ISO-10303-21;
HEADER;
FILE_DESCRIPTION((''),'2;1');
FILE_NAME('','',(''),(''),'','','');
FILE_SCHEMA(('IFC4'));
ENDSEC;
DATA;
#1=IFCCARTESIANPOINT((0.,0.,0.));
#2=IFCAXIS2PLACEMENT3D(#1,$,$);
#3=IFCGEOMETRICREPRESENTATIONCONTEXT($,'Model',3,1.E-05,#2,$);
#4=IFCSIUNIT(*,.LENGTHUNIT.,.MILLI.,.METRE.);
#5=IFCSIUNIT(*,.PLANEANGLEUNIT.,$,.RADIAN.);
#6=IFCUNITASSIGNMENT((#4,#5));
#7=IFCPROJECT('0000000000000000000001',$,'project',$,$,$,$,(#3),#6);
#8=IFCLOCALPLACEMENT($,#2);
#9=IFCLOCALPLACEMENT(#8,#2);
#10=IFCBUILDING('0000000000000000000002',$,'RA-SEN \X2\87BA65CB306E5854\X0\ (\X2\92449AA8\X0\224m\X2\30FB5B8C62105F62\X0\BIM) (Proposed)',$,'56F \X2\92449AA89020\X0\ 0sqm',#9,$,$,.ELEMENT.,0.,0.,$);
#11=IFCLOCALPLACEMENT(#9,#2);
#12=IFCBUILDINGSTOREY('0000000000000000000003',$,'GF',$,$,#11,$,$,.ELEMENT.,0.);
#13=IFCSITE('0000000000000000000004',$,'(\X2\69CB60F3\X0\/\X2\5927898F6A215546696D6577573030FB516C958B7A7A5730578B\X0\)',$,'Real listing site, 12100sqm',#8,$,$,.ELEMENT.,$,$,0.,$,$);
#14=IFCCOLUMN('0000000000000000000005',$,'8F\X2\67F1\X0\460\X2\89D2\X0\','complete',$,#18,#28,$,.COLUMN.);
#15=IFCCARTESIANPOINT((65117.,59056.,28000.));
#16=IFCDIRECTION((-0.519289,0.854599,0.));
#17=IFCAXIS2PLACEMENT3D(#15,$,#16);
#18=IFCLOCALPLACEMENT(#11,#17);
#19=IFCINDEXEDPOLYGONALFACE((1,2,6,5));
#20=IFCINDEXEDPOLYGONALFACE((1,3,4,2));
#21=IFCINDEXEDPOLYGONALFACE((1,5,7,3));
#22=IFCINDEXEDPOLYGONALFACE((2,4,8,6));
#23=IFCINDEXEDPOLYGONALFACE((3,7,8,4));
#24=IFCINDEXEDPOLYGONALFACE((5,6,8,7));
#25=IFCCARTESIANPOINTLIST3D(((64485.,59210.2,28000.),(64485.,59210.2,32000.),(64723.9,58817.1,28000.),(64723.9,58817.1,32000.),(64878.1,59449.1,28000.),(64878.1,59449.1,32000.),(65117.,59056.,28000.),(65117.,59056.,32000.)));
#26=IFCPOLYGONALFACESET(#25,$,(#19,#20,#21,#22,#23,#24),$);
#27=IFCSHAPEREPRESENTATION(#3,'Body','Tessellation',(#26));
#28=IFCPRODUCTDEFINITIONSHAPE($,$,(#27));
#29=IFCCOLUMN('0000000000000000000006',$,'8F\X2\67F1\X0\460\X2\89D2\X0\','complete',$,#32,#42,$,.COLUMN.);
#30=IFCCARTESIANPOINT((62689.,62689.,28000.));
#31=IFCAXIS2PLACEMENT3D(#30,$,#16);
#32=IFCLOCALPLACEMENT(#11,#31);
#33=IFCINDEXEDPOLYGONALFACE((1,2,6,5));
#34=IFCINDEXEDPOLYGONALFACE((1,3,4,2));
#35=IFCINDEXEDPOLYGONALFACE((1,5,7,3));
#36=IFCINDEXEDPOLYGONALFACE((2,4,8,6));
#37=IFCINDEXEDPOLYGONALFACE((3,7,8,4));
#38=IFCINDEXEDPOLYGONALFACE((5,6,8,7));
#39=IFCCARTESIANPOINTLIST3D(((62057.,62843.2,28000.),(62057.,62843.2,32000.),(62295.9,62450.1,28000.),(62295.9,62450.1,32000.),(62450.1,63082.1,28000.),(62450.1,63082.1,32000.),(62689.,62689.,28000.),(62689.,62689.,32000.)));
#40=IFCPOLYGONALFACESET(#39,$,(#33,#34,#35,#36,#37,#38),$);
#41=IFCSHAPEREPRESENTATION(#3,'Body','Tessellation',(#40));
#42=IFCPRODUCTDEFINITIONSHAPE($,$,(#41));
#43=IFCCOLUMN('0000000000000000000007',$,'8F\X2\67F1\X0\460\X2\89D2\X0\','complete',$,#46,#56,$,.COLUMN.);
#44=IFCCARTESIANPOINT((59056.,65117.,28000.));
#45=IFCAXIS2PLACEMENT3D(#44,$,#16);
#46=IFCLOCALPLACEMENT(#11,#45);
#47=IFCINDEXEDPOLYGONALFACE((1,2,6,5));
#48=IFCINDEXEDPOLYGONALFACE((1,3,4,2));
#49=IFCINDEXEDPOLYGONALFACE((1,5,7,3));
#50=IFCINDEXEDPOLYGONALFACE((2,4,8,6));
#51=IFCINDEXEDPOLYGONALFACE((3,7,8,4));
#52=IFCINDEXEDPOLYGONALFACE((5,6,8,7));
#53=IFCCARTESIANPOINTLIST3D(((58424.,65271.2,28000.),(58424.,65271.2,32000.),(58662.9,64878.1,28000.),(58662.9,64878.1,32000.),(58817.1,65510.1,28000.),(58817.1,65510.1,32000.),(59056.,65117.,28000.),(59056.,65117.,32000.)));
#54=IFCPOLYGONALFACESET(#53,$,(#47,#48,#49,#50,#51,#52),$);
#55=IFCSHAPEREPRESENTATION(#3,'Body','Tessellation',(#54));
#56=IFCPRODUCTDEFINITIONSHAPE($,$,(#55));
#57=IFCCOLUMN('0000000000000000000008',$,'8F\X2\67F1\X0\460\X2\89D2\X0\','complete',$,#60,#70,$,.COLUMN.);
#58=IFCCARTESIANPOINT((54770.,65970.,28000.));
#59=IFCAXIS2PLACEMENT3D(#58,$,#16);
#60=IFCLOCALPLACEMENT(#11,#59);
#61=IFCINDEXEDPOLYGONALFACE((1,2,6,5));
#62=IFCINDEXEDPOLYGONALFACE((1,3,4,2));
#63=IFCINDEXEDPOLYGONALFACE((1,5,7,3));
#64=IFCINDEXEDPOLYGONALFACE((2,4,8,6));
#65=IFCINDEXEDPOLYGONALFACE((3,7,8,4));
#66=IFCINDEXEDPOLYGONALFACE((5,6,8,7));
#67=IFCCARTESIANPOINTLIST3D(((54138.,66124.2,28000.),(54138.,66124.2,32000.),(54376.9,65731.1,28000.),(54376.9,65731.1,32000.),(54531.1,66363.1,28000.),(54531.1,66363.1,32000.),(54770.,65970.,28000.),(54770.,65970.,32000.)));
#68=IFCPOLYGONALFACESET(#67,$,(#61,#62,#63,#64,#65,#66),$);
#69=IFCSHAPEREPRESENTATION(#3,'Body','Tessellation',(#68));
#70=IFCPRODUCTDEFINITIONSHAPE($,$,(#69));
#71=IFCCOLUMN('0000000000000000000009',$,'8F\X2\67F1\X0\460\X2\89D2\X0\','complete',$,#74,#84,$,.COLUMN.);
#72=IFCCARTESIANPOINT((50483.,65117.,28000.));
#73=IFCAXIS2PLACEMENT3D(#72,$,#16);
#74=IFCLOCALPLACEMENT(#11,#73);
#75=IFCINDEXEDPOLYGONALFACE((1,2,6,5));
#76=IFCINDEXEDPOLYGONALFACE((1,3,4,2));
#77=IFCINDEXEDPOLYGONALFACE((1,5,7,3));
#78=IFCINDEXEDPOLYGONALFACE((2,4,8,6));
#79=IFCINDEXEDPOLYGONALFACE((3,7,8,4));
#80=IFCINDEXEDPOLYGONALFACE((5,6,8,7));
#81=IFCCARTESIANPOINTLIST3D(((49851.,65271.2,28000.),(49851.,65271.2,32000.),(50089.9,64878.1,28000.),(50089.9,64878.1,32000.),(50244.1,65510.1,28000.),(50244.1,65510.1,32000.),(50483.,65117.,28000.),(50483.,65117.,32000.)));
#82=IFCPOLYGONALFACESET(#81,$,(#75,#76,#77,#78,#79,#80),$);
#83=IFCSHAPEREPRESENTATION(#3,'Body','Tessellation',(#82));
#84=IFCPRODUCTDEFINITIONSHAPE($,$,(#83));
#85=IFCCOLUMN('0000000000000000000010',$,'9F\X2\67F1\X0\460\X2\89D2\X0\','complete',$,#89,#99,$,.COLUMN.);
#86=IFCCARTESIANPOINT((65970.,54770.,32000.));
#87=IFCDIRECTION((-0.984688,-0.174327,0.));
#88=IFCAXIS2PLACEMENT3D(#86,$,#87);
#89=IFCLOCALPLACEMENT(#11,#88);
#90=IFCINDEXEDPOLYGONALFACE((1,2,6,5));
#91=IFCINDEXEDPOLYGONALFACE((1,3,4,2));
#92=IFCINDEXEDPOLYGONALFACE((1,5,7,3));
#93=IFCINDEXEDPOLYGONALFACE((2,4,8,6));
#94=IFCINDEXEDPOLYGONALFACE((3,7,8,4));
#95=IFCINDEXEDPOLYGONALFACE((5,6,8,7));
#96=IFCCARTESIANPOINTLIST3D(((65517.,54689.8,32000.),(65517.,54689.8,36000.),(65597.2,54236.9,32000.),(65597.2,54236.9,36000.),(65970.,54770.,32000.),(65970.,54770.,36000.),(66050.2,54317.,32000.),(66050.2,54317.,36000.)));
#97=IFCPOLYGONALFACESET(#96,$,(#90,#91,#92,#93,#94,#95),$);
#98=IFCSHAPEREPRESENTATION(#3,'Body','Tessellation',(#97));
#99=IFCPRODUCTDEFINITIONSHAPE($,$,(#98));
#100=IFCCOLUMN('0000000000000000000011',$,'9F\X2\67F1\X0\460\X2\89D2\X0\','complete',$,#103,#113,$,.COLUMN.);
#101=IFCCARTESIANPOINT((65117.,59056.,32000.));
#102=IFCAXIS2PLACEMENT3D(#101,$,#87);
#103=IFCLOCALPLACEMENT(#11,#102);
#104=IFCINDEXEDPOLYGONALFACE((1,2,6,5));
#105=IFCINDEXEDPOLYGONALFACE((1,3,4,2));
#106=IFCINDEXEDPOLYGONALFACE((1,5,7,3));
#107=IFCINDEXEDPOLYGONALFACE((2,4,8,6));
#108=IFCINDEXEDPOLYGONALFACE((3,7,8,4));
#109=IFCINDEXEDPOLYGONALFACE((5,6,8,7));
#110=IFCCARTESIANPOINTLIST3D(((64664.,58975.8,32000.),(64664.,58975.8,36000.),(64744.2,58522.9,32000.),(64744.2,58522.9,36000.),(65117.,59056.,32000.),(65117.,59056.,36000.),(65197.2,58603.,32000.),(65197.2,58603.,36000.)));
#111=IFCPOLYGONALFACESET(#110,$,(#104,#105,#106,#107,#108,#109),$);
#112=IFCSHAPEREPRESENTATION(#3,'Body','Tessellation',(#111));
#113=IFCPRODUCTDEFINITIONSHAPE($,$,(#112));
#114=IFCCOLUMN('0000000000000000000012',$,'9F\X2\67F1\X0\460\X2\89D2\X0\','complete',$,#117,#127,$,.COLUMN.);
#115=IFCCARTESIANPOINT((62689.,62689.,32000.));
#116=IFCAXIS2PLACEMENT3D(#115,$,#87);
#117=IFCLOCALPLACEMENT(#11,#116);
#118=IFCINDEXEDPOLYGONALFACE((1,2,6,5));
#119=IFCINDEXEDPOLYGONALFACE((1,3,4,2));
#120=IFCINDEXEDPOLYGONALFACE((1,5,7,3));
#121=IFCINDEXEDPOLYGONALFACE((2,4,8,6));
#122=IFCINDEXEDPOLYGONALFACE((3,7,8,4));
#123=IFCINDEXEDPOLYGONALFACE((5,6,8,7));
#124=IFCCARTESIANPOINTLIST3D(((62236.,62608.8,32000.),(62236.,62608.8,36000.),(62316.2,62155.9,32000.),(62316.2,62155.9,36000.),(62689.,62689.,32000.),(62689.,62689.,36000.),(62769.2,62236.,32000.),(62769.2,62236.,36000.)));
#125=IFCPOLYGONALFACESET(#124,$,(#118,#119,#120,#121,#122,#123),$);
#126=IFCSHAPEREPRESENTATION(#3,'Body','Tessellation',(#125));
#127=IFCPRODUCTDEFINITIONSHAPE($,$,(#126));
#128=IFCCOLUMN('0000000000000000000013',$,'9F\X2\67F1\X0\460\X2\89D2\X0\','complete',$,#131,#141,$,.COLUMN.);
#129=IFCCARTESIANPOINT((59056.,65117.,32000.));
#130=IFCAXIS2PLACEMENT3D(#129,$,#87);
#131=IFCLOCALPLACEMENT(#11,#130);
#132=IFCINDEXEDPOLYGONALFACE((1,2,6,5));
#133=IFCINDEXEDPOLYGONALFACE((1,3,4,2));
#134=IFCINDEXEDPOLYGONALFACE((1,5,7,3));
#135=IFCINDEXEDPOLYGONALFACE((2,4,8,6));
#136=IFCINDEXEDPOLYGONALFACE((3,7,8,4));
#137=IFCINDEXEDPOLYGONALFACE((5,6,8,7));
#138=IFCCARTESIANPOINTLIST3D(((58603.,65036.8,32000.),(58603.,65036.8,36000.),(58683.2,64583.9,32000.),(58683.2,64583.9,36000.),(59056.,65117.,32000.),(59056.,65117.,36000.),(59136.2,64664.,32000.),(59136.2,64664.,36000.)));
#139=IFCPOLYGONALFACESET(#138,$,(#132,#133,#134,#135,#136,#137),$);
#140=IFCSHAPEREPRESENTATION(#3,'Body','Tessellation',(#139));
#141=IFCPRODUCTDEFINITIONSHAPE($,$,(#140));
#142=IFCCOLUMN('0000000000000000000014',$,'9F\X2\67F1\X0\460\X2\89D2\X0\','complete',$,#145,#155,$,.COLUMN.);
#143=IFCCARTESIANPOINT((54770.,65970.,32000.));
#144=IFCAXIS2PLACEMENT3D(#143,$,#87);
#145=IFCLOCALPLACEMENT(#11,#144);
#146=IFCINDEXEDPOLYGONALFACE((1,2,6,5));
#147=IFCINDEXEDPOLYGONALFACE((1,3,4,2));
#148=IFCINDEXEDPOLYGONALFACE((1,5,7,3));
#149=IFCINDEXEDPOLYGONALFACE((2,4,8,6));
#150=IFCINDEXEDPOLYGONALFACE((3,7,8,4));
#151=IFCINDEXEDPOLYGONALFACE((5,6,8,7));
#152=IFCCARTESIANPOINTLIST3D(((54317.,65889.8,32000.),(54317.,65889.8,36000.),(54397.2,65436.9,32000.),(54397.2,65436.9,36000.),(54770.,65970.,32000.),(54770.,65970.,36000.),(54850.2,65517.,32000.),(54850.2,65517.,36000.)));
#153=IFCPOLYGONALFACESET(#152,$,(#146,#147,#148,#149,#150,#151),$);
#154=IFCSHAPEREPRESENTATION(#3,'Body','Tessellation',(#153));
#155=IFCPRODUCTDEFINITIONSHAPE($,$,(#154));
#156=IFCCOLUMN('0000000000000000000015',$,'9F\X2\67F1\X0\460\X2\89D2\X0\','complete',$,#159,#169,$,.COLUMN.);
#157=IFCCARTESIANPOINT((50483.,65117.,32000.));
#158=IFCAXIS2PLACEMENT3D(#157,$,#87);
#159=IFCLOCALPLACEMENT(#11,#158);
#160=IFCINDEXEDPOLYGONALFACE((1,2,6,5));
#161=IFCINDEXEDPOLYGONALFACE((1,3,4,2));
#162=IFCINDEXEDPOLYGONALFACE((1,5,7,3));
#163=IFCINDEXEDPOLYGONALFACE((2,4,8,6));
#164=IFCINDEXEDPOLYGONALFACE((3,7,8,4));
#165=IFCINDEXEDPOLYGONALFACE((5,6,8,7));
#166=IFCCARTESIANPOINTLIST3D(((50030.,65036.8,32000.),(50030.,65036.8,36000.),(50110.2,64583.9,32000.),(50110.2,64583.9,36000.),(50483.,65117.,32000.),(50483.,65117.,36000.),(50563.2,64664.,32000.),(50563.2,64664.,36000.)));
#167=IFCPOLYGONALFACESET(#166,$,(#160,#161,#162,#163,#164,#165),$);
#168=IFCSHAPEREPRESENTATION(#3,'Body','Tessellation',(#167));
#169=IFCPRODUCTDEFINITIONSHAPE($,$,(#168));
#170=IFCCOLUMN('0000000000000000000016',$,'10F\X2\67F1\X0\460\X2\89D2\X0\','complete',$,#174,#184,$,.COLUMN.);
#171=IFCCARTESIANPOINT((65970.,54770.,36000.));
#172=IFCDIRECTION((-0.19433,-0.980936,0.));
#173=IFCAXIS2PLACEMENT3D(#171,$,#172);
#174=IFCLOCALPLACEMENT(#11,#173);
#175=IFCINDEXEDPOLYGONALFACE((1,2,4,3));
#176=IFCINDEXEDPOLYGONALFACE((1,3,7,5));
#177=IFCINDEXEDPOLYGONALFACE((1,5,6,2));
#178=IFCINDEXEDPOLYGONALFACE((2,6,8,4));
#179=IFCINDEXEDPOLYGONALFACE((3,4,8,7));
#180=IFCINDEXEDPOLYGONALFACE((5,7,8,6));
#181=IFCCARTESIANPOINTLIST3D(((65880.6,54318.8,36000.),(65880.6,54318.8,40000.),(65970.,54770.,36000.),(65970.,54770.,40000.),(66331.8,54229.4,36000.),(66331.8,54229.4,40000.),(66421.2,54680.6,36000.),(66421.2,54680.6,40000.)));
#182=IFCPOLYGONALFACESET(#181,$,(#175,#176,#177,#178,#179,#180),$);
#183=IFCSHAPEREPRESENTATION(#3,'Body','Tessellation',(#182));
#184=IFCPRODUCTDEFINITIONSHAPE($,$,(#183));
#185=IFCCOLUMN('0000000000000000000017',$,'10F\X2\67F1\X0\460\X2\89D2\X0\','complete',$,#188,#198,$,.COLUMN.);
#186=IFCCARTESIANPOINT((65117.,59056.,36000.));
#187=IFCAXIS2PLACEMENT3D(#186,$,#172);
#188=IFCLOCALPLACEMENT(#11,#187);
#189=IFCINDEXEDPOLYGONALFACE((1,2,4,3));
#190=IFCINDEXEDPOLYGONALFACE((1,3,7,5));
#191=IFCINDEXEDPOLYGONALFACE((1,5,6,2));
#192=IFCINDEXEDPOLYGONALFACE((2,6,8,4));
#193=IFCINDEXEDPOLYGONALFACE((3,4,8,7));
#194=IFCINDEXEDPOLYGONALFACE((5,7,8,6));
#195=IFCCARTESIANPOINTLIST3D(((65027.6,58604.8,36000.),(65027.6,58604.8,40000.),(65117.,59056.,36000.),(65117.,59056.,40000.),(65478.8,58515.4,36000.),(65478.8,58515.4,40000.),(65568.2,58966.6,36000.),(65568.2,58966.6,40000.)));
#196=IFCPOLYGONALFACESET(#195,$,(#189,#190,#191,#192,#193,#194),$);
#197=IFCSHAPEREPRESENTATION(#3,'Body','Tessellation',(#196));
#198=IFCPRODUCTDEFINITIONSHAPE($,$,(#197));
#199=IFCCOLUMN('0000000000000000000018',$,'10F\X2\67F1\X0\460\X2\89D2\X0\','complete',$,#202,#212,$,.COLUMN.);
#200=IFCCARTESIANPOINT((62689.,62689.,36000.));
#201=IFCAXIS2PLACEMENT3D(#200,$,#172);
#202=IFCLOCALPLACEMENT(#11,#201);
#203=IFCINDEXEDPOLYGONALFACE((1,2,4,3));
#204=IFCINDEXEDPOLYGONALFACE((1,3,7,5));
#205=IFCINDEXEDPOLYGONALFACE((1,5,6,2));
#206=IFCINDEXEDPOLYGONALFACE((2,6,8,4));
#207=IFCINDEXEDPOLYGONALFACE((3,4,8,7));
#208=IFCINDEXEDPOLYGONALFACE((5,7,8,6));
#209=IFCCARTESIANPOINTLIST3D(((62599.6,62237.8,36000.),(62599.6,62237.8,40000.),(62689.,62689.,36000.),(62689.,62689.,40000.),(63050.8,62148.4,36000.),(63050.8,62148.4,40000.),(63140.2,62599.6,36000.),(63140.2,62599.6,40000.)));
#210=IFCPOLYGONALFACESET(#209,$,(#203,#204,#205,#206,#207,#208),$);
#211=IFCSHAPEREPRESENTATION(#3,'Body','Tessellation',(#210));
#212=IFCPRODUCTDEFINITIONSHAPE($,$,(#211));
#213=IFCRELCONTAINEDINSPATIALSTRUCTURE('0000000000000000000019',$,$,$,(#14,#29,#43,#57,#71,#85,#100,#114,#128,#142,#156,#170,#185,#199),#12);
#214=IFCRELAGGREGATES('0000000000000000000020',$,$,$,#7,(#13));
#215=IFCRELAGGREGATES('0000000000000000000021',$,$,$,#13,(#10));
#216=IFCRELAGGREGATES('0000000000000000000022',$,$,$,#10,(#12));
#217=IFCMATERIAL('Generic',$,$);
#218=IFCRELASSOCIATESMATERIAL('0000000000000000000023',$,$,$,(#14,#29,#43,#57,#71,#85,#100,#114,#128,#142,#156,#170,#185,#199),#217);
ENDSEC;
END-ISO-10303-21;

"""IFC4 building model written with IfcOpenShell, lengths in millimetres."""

from ifc_helpers import new_model, si_unit, frame, frame_2d, origin, place, context, project, spatial, rectangle, extrude, material, element, save


model = new_model("IFC4")

# Units and contexts
model_context = context("Model", 3, precision=1e-05, world=origin())
ifc_project = project(units=[si_unit("LENGTHUNIT", "METRE", prefix="MILLI"), si_unit("PLANEANGLEUNIT", "RADIAN")], contexts=[model_context])

# Site, building, storey
site_placement = place(None, origin())
site = spatial("IfcSite", under=ifc_project, at=site_placement, Name="(構想/大規模商業敷地・公開空地型)", ObjectType="Real listing site, 12100sqm", CompositionType="ELEMENT", RefElevation=0.0)
building_placement = place(site_placement, origin())
building = spatial("IfcBuilding", under=site, at=building_placement, Name="RA-SEN 螺旋の塔 (鉄骨224m・完成形BIM) (Proposed)", ObjectType="56F 鉄骨造 0sqm", CompositionType="ELEMENT", ElevationOfRefHeight=0.0, ElevationOfTerrain=0.0)
storey_placement = place(building_placement, origin())
storey = spatial("IfcBuildingStorey", under=building, at=storey_placement, Name="GF", CompositionType="ELEMENT", Elevation=0.0)

# Columns
ifc_material = material(Name="Generic")
column_1_placement = place(storey_placement, frame((65117.0, 59056.0, 28000.0), x_axis=(-0.519289, 0.854599, 0.0)))
element("IfcColumn", 1, at=column_1_placement, inside=storey, material=ifc_material, Name="8F柱460角", Description="complete", PredefinedType="COLUMN", context=model_context, shape_type="SweptSolid", body=[
    extrude(rectangle(XDim=460.0, YDim=460.0, at=frame_2d((230.0, 230.0))), frame((65117.0, 59056.0, 28000.0), x_axis=(-0.519289, 0.854599, 0.0)), (0.0, 0.0, 1.0), 4000.0),
])
column_2_placement = place(storey_placement, frame((62689.0, 62689.0, 28000.0), x_axis=(-0.519289, 0.854599, 0.0)))
element("IfcColumn", 2, at=column_2_placement, inside=storey, material=ifc_material, Name="8F柱460角", Description="complete", PredefinedType="COLUMN", context=model_context, shape_type="SweptSolid", body=[
    extrude(rectangle(XDim=460.0, YDim=460.0, at=frame_2d((230.0, 230.0))), frame((62689.0, 62689.0, 28000.0), x_axis=(-0.519289, 0.854599, 0.0)), (0.0, 0.0, 1.0), 4000.0),
])
column_3_placement = place(storey_placement, frame((59056.0, 65117.0, 28000.0), x_axis=(-0.519289, 0.854599, 0.0)))
element("IfcColumn", 3, at=column_3_placement, inside=storey, material=ifc_material, Name="8F柱460角", Description="complete", PredefinedType="COLUMN", context=model_context, shape_type="SweptSolid", body=[
    extrude(rectangle(XDim=460.0, YDim=460.0, at=frame_2d((230.0, 230.0))), frame((59056.0, 65117.0, 28000.0), x_axis=(-0.519289, 0.854599, 0.0)), (0.0, 0.0, 1.0), 4000.0),
])
column_4_placement = place(storey_placement, frame((54770.0, 65970.0, 28000.0), x_axis=(-0.519289, 0.854599, 0.0)))
element("IfcColumn", 4, at=column_4_placement, inside=storey, material=ifc_material, Name="8F柱460角", Description="complete", PredefinedType="COLUMN", context=model_context, shape_type="SweptSolid", body=[
    extrude(rectangle(XDim=460.0, YDim=460.0, at=frame_2d((230.0, 230.0))), frame((54770.0, 65970.0, 28000.0), x_axis=(-0.519289, 0.854599, 0.0)), (0.0, 0.0, 1.0), 4000.0),
])
column_5_placement = place(storey_placement, frame((50483.0, 65117.0, 28000.0), x_axis=(-0.519289, 0.854599, 0.0)))
element("IfcColumn", 5, at=column_5_placement, inside=storey, material=ifc_material, Name="8F柱460角", Description="complete", PredefinedType="COLUMN", context=model_context, shape_type="SweptSolid", body=[
    extrude(rectangle(XDim=460.0, YDim=460.0, at=frame_2d((230.0, 230.0))), frame((50483.0, 65117.0, 28000.0), x_axis=(-0.519289, 0.854599, 0.0)), (0.0, 0.0, 1.0), 4000.0),
])
column_6_placement = place(storey_placement, frame((65970.0, 54770.0, 32000.0), x_axis=(-0.984688, -0.174327, 0.0)))
element("IfcColumn", 6, at=column_6_placement, inside=storey, material=ifc_material, Name="9F柱460角", Description="complete", PredefinedType="COLUMN", context=model_context, shape_type="SweptSolid", body=[
    extrude(rectangle(XDim=460.0, YDim=460.0, at=frame_2d((230.0, 230.0))), frame((65970.0, 54770.0, 32000.0), x_axis=(-0.984688, -0.174327, 0.0)), (0.0, 0.0, 1.0), 4000.0),
])
column_7_placement = place(storey_placement, frame((65117.0, 59056.0, 32000.0), x_axis=(-0.984688, -0.174327, 0.0)))
element("IfcColumn", 7, at=column_7_placement, inside=storey, material=ifc_material, Name="9F柱460角", Description="complete", PredefinedType="COLUMN", context=model_context, shape_type="SweptSolid", body=[
    extrude(rectangle(XDim=460.0, YDim=460.0, at=frame_2d((230.0, 230.0))), frame((65117.0, 59056.0, 32000.0), x_axis=(-0.984688, -0.174327, 0.0)), (0.0, 0.0, 1.0), 4000.0),
])
column_8_placement = place(storey_placement, frame((62689.0, 62689.0, 32000.0), x_axis=(-0.984688, -0.174327, 0.0)))
element("IfcColumn", 8, at=column_8_placement, inside=storey, material=ifc_material, Name="9F柱460角", Description="complete", PredefinedType="COLUMN", context=model_context, shape_type="SweptSolid", body=[
    extrude(rectangle(XDim=460.0, YDim=460.0, at=frame_2d((230.0, 230.0))), frame((62689.0, 62689.0, 32000.0), x_axis=(-0.984688, -0.174327, 0.0)), (0.0, 0.0, 1.0), 4000.0),
])
column_9_placement = place(storey_placement, frame((59056.0, 65117.0, 32000.0), x_axis=(-0.984688, -0.174327, 0.0)))
element("IfcColumn", 9, at=column_9_placement, inside=storey, material=ifc_material, Name="9F柱460角", Description="complete", PredefinedType="COLUMN", context=model_context, shape_type="SweptSolid", body=[
    extrude(rectangle(XDim=460.0, YDim=460.0, at=frame_2d((230.0, 230.0))), frame((59056.0, 65117.0, 32000.0), x_axis=(-0.984688, -0.174327, 0.0)), (0.0, 0.0, 1.0), 4000.0),
])
column_10_placement = place(storey_placement, frame((54770.0, 65970.0, 32000.0), x_axis=(-0.984688, -0.174327, 0.0)))
element("IfcColumn", 10, at=column_10_placement, inside=storey, material=ifc_material, Name="9F柱460角", Description="complete", PredefinedType="COLUMN", context=model_context, shape_type="SweptSolid", body=[
    extrude(rectangle(XDim=460.0, YDim=460.0, at=frame_2d((230.0, 230.0))), frame((54770.0, 65970.0, 32000.0), x_axis=(-0.984688, -0.174327, 0.0)), (0.0, 0.0, 1.0), 4000.0),
])
column_11_placement = place(storey_placement, frame((50483.0, 65117.0, 32000.0), x_axis=(-0.984688, -0.174327, 0.0)))
element("IfcColumn", 11, at=column_11_placement, inside=storey, material=ifc_material, Name="9F柱460角", Description="complete", PredefinedType="COLUMN", context=model_context, shape_type="SweptSolid", body=[
    extrude(rectangle(XDim=460.0, YDim=460.0, at=frame_2d((230.0, 230.0))), frame((50483.0, 65117.0, 32000.0), x_axis=(-0.984688, -0.174327, 0.0)), (0.0, 0.0, 1.0), 4000.0),
])
column_12_placement = place(storey_placement, frame((65970.0, 54770.0, 36000.0), x_axis=(-0.19433, -0.980936, 0.0)))
element("IfcColumn", 12, at=column_12_placement, inside=storey, material=ifc_material, Name="10F柱460角", Description="complete", PredefinedType="COLUMN", context=model_context, shape_type="SweptSolid", body=[
    extrude(rectangle(XDim=460.0, YDim=460.0, at=frame_2d((230.0, 230.0))), frame((65970.0, 54770.0, 36000.0), x_axis=(-0.19433, -0.980936, 0.0)), (0.0, 0.0, 1.0), 4000.0),
])
column_13_placement = place(storey_placement, frame((65117.0, 59056.0, 36000.0), x_axis=(-0.19433, -0.980936, 0.0)))
element("IfcColumn", 13, at=column_13_placement, inside=storey, material=ifc_material, Name="10F柱460角", Description="complete", PredefinedType="COLUMN", context=model_context, shape_type="SweptSolid", body=[
    extrude(rectangle(XDim=460.0, YDim=460.0, at=frame_2d((230.0, 230.0))), frame((65117.0, 59056.0, 36000.0), x_axis=(-0.19433, -0.980936, 0.0)), (0.0, 0.0, 1.0), 4000.0),
])
column_14_placement = place(storey_placement, frame((62689.0, 62689.0, 36000.0), x_axis=(-0.19433, -0.980936, 0.0)))
element("IfcColumn", 14, at=column_14_placement, inside=storey, material=ifc_material, Name="10F柱460角", Description="complete", PredefinedType="COLUMN", context=model_context, shape_type="SweptSolid", body=[
    extrude(rectangle(XDim=460.0, YDim=460.0, at=frame_2d((230.0, 230.0))), frame((62689.0, 62689.0, 36000.0), x_axis=(-0.19433, -0.980936, 0.0)), (0.0, 0.0, 1.0), 4000.0),
])

save(model, "model.ifc")
